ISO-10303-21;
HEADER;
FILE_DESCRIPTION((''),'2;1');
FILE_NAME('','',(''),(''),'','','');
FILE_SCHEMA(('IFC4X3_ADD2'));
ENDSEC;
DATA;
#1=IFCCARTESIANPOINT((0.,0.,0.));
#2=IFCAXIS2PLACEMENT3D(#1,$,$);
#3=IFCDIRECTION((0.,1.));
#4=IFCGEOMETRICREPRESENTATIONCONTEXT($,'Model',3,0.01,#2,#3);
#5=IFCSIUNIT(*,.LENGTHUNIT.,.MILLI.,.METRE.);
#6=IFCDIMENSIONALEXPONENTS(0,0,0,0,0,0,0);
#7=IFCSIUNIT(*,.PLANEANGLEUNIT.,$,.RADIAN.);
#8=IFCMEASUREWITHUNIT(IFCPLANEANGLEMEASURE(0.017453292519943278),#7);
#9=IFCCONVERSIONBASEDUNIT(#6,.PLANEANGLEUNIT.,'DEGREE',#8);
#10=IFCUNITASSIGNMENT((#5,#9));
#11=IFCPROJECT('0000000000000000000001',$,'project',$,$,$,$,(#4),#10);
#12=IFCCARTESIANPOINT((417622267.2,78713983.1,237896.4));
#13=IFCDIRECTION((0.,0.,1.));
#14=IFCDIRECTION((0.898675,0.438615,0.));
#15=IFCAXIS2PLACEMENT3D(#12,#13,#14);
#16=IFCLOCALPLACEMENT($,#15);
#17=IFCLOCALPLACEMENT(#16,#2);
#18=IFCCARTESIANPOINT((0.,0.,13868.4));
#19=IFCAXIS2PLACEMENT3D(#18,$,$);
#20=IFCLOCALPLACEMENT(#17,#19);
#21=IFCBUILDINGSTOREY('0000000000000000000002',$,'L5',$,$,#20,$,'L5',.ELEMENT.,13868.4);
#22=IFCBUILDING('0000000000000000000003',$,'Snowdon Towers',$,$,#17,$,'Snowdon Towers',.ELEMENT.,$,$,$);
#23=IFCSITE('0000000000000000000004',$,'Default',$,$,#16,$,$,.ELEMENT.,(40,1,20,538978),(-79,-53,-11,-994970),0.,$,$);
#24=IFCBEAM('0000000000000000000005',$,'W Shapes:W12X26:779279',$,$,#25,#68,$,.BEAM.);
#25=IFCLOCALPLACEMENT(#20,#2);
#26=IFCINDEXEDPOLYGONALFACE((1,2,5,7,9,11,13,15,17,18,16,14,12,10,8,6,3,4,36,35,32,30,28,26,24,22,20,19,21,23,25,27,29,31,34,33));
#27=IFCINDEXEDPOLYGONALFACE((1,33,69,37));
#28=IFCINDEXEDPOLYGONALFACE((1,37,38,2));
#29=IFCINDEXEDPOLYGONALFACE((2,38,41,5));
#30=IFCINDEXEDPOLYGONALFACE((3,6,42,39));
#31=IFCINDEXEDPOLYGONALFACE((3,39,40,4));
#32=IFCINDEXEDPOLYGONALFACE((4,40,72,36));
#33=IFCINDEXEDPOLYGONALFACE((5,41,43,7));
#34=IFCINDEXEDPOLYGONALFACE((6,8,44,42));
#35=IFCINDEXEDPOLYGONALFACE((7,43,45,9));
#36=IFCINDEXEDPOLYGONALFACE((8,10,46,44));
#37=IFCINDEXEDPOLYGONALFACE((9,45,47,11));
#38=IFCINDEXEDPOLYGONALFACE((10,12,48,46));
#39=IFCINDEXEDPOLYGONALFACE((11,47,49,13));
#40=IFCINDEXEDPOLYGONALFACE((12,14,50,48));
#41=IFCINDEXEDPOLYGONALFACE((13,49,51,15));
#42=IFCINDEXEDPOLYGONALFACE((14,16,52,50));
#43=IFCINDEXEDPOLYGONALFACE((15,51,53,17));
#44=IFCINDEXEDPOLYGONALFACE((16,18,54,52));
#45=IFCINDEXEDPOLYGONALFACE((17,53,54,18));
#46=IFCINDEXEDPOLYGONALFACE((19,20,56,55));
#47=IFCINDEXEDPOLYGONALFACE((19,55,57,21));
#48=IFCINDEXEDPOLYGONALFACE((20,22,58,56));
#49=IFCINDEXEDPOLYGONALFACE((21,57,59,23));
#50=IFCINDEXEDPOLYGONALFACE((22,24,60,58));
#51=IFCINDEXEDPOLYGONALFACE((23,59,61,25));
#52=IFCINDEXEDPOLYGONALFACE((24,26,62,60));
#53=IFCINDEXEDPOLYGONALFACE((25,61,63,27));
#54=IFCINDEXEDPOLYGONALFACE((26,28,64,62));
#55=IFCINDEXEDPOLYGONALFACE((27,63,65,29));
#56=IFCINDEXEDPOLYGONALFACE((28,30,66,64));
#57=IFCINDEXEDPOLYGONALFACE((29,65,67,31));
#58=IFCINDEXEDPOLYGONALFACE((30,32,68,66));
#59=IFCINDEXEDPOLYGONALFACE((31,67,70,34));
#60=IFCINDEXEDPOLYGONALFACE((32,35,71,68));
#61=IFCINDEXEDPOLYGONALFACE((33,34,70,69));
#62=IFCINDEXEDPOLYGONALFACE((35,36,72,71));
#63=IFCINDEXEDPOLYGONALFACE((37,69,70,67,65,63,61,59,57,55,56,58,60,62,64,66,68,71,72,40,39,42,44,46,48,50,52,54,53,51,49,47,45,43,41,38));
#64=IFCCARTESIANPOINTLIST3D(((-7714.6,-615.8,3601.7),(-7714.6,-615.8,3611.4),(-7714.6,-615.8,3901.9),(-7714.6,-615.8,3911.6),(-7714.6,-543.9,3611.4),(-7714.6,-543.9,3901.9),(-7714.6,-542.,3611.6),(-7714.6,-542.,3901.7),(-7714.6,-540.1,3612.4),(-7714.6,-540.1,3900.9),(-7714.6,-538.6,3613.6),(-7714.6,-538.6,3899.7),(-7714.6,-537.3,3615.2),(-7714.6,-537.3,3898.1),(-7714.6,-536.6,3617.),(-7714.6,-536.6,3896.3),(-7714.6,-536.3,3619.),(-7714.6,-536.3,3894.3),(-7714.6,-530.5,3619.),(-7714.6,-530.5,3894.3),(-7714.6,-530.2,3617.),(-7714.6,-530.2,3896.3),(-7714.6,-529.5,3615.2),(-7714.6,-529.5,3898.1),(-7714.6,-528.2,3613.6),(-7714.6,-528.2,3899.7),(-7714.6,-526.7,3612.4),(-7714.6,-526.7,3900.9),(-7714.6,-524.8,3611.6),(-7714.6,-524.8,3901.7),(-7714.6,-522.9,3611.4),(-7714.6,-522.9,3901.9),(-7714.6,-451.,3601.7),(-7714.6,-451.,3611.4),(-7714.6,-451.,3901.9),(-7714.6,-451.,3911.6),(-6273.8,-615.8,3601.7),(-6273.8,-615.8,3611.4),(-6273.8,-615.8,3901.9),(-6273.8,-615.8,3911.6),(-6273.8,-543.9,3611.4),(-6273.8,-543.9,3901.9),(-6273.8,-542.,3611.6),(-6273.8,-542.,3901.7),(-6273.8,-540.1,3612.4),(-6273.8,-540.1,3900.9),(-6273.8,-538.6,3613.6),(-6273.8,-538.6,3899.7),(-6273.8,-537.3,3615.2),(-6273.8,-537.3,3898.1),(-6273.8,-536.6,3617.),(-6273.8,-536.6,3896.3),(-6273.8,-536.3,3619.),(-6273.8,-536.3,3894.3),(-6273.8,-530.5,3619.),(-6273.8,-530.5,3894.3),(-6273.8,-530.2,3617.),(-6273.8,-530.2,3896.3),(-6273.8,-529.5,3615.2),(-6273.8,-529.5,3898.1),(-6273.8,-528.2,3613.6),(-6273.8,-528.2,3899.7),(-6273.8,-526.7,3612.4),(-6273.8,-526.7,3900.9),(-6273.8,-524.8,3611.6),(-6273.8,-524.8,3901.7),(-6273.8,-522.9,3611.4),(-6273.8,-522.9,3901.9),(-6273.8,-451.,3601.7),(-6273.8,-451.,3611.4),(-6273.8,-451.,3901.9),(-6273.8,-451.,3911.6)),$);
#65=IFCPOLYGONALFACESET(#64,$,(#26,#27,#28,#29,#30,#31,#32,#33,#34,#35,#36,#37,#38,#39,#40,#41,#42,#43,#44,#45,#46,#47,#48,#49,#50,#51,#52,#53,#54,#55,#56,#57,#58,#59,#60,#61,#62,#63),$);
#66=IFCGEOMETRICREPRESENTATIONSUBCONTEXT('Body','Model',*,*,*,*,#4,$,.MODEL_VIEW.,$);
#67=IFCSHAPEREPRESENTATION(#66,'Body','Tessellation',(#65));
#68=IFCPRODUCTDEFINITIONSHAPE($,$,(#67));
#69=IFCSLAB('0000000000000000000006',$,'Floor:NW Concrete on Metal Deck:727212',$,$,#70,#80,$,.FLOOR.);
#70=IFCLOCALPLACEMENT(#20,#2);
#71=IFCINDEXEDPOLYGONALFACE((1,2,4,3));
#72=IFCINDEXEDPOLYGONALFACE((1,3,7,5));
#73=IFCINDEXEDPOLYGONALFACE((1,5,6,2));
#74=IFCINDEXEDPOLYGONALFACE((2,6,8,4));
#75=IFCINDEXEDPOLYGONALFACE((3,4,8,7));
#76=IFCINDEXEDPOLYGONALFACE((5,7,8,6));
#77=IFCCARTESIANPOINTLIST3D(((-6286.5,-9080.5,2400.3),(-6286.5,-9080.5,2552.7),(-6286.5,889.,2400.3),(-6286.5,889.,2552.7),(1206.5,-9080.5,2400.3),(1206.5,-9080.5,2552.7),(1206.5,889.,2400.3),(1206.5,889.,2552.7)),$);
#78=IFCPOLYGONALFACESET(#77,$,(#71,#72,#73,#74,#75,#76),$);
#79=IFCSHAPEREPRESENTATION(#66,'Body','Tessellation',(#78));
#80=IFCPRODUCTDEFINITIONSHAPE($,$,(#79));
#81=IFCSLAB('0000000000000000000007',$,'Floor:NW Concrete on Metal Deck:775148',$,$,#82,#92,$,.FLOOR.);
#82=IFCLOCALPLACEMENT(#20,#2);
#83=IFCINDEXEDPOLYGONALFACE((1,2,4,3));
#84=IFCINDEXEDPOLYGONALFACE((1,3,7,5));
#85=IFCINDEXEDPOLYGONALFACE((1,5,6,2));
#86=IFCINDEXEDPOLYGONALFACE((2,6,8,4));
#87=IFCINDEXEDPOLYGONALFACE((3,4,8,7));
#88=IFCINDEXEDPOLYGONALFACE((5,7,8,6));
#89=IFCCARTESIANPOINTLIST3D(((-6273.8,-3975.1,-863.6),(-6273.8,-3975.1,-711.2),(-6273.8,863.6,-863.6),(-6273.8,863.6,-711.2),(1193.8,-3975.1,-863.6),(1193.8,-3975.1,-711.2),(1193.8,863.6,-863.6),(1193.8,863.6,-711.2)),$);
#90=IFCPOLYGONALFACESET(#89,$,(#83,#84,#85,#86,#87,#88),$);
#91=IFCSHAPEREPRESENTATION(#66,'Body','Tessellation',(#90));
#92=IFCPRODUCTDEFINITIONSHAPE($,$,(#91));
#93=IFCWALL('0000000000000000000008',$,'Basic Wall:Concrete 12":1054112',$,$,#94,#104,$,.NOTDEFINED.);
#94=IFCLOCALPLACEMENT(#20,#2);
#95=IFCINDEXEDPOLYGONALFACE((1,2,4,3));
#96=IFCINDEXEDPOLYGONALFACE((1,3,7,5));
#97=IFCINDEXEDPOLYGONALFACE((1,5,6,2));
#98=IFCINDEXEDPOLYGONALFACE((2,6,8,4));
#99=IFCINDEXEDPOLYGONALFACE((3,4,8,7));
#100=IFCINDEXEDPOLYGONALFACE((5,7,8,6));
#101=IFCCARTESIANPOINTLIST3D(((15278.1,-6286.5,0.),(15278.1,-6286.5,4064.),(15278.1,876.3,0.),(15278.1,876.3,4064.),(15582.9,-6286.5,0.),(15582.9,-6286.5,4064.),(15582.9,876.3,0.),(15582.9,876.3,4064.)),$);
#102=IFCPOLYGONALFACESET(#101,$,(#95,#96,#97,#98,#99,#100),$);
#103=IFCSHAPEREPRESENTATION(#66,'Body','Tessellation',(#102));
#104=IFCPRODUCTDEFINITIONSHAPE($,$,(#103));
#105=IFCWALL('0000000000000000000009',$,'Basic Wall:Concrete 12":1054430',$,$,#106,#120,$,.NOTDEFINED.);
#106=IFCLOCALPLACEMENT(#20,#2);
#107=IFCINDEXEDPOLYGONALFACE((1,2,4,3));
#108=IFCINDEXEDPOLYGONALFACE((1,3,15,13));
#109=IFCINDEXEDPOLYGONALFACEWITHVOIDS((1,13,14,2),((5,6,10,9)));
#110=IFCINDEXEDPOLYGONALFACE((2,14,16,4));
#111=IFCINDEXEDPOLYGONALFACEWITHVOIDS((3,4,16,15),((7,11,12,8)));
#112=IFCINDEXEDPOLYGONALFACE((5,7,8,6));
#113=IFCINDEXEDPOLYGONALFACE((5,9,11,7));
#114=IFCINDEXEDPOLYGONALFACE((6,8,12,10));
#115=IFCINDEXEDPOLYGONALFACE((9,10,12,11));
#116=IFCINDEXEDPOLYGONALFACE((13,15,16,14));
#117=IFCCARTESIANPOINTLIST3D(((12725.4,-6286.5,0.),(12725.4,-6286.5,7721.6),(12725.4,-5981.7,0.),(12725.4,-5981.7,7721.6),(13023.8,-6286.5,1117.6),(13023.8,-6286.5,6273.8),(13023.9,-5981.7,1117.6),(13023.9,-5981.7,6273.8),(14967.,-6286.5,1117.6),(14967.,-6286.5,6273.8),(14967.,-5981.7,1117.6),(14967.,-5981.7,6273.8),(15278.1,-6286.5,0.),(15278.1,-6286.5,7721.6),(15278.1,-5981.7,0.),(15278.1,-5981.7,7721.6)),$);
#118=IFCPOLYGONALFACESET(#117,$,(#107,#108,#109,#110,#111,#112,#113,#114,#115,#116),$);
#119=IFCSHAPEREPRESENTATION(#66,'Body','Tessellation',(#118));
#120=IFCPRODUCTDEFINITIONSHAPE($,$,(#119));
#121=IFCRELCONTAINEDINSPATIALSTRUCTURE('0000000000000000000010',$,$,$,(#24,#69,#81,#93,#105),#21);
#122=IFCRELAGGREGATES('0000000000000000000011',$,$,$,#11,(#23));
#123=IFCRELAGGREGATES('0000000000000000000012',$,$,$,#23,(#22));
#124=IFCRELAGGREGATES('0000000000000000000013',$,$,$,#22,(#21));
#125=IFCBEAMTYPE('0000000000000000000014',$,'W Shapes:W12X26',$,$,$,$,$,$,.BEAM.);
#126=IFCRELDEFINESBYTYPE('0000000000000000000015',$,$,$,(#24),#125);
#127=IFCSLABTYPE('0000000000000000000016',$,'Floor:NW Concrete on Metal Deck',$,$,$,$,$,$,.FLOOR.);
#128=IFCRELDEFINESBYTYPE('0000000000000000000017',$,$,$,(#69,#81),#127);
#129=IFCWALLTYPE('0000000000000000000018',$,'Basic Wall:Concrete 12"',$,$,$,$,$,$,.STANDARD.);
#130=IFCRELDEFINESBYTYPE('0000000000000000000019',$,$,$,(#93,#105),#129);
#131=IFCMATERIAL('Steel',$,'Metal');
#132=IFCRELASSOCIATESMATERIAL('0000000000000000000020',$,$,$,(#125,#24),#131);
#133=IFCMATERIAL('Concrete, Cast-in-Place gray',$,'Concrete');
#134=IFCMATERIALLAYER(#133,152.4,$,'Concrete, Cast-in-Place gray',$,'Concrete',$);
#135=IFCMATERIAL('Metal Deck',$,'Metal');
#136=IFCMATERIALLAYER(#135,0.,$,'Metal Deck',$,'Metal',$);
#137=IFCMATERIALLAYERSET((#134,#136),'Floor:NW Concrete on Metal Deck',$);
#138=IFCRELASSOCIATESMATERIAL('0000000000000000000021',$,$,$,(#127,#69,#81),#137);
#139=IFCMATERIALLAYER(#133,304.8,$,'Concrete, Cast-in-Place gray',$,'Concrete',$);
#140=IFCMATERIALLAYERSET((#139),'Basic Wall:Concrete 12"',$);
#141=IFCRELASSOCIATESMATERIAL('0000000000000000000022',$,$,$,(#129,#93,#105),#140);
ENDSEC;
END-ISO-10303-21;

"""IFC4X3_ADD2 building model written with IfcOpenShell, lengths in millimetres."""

from ifc_helpers import new_model, entity, si_unit, converted_unit, direction, frame, frame_2d, origin, place, context, subcontext, project, spatial, polyline, circle_curve, parameter, trimmed, segment, composite_curve, rectangle, i_section, outline, extrude, source, transform, mapped, material, layer, layer_set, layer_usage, material_profile, profile_set, profile_usage, type_object, type_shapes, element, save


model = new_model("IFC4X3_ADD2")

# Units and contexts
model_context = context("Model", 3, precision=0.01, world=origin(), true_north=direction((0.0, 1.0)))
body_context = subcontext(model_context, "Body", "Model", "MODEL_VIEW")
ifc_project = project(units=[si_unit("LENGTHUNIT", "METRE", prefix="MILLI"), converted_unit("PLANEANGLEUNIT", "DEGREE", entity("IfcPlaneAngleMeasure", 0.017453292519943278), si_unit("PLANEANGLEUNIT", "RADIAN"), dimensions=[0, 0, 0, 0, 0, 0, 0])], contexts=[model_context])

# Site, building, storey
site_placement = place(None, frame((417622267.2, 78713983.1, 237896.4), z_axis=(0.0, 0.0, 1.0), x_axis=(0.898675, 0.438615, 0.0)))
site = spatial("IfcSite", under=ifc_project, at=site_placement, Name="Default", CompositionType="ELEMENT", RefLatitude=(40, 1, 20, 538978), RefLongitude=(-79, -53, -11, -994970), RefElevation=0.0)
building_placement = place(site_placement, origin())
building = spatial("IfcBuilding", under=site, at=building_placement, Name="Snowdon Towers", LongName="Snowdon Towers", CompositionType="ELEMENT")
storey_placement = place(building_placement, frame((0.0, 0.0, 13868.4)))
storey = spatial("IfcBuildingStorey", under=building, at=storey_placement, Name="L5", LongName="L5", CompositionType="ELEMENT", Elevation=13868.4)

# Shared definitions
ifc_material_1 = material(Name="Steel", Category="Metal")

# Beam
ifc_material_profile_1 = material_profile(ifc_material_1, outline(composite_curve([segment(polyline([(-82.4, -145.3), (-82.4, -154.9)]), True, "CONTINUOUS"), segment(polyline([(-82.4, -154.9), (82.4, -154.9)]), True, "CONTINUOUS"), segment(polyline([(82.4, -154.9), (82.4, -145.3)]), True, "CONTINUOUS"), segment(polyline([(82.4, -145.3), (10.5, -145.3)]), True, "CONTINUOUS"), segment(trimmed(circle_curve(frame_2d((10.5, -137.7), x_axis=(1.0, 0.0)), 7.6), [parameter(180.0)], [parameter(270.0)], True, "PARAMETER"), False, "CONTINUOUS"), segment(polyline([(2.9, -137.7), (2.9, 137.7)]), True, "CONTINUOUS"), segment(trimmed(circle_curve(frame_2d((10.5, 137.7), x_axis=(1.0, 0.0)), 7.6), [parameter(90.0)], [parameter(180.0)], True, "PARAMETER"), False, "CONTINUOUS"), segment(polyline([(10.5, 145.3), (82.4, 145.3)]), True, "CONTINUOUS"), segment(polyline([(82.4, 145.3), (82.4, 154.9)]), True, "CONTINUOUS"), segment(polyline([(82.4, 154.9), (-82.4, 154.9)]), True, "CONTINUOUS"), segment(polyline([(-82.4, 154.9), (-82.4, 145.3)]), True, "CONTINUOUS"), segment(polyline([(-82.4, 145.3), (-10.5, 145.3)]), True, "CONTINUOUS"), segment(trimmed(circle_curve(frame_2d((-10.5, 137.7), x_axis=(1.0, 0.0)), 7.6), [parameter(360.0)], [parameter(90.0)], True, "PARAMETER"), False, "CONTINUOUS"), segment(polyline([(-2.9, 137.7), (-2.9, -137.7)]), True, "CONTINUOUS"), segment(trimmed(circle_curve(frame_2d((-10.5, -137.7), x_axis=(1.0, 0.0)), 7.6), [parameter(270.0)], [parameter(360.0)], True, "PARAMETER"), False, "CONTINUOUS"), segment(polyline([(-10.5, -145.3), (-82.4, -145.3)]), True, "CONTINUOUS")], self_intersect=False)), Name="W12X26")
ifc_profile_set_1 = profile_set([ifc_material_profile_1], Name="W12X26")
ifc_profile_usage_1 = profile_usage(ifc_profile_set_1, cardinal=8)
beam_type_1 = type_object("IfcBeamType", Name="W Shapes:W12X26", PredefinedType="BEAM", material=ifc_profile_set_1)
shared_shape_1 = source(origin(), body_context, "Body", "SweptSolid", [
    extrude(i_section(OverallWidth=164.8, OverallDepth=309.9, WebThickness=5.8, FlangeThickness=9.7, FilletRadius=7.6, at=frame_2d((0.0, 0.0), x_axis=(0.0, 1.0))), frame((-6273.8, -533.4, 17625.1), z_axis=(-1.0, 0.0, 0.0), x_axis=(0.0, 0.0, -1.0)), (0.0, 0.0, 1.0), 1440.8),
])
type_shapes(beam_type_1, [shared_shape_1])
beam_1_placement = place(storey_placement, frame((0.0, 0.0, -13868.4)))
element("IfcBeam", 1, at=beam_1_placement, inside=storey, type_object=beam_type_1, material=ifc_profile_usage_1, Name="W Shapes:W12X26:779279", PredefinedType="BEAM", context=body_context, shape_type="MappedRepresentation", body=[
    mapped(shared_shape_1, transform((0.0, 0.0, 0.0), scale=1.0)),
])

# Slabs
ifc_material_2 = material(Name="Concrete, Cast-in-Place gray", Category="Concrete")
ifc_layer_1 = layer(ifc_material_2, 152.4, Name="Concrete, Cast-in-Place gray", Category="Concrete")
ifc_material_3 = material(Name="Metal Deck", Category="Metal")
ifc_layer_2 = layer(ifc_material_3, 0.0, Name="Metal Deck", Category="Metal")
ifc_layer_set_1 = layer_set([ifc_layer_1, ifc_layer_2], Name="Floor:NW Concrete on Metal Deck")
ifc_layer_usage_1 = layer_usage(ifc_layer_set_1, "AXIS3", "POSITIVE", 0.0)
slab_type = type_object("IfcSlabType", Name="Floor:NW Concrete on Metal Deck", PredefinedType="FLOOR", material=ifc_layer_set_1)
slab_1_placement = place(storey_placement, origin())
element("IfcSlab", 2, at=slab_1_placement, inside=storey, type_object=slab_type, material=ifc_layer_usage_1, Name="Floor:NW Concrete on Metal Deck:727212", PredefinedType="FLOOR", context=body_context, shape_type="SweptSolid", body=[
    extrude(rectangle(XDim=9969.5, YDim=7493.0, at=frame_2d((0.0, 0.0), x_axis=(1.0, 0.0))), frame((-2540.0, -4095.8, 2552.7), z_axis=(0.0, 0.0, -1.0), x_axis=(0.0, 1.0, 0.0)), (0.0, 0.0, 1.0), 152.4),
])
ifc_layer_usage_2 = layer_usage(ifc_layer_set_1, "AXIS3", "POSITIVE", 0.0)
slab_2_placement = place(storey_placement, origin())
element("IfcSlab", 3, at=slab_2_placement, inside=storey, type_object=slab_type, material=ifc_layer_usage_2, Name="Floor:NW Concrete on Metal Deck:775148", PredefinedType="FLOOR", context=body_context, shape_type="SweptSolid", body=[
    extrude(rectangle(XDim=4838.7, YDim=7467.6, at=frame_2d((0.0, 0.0), x_axis=(1.0, 0.0))), frame((-2540.0, -1555.8, -711.2), z_axis=(0.0, 0.0, -1.0), x_axis=(0.0, 1.0, 0.0)), (0.0, 0.0, 1.0), 152.4),
])

# Wall
ifc_layer_3 = layer(ifc_material_2, 304.8, Name="Concrete, Cast-in-Place gray", Category="Concrete")
ifc_layer_set_2 = layer_set([ifc_layer_3], Name="Basic Wall:Concrete 12\"")
wall_type = type_object("IfcWallType", Name="Basic Wall:Concrete 12\"", PredefinedType="STANDARD", material=ifc_layer_set_2)
wall_1_placement = place(storey_placement, frame((15430.5, -6286.5, 0.0), z_axis=(0.0, 0.0, 1.0), x_axis=(0.0, 1.0, 0.0)))
element("IfcWall", 4, at=wall_1_placement, inside=storey, type_object=wall_type, material=ifc_layer_set_2, Name="Basic Wall:Concrete 12\":1054112", PredefinedType="NOTDEFINED", context=body_context, shape_type="SweptSolid", body=[
    extrude(rectangle(XDim=7162.8, YDim=304.8, at=frame_2d((3581.4, 0.0), x_axis=(-1.0, 0.0))), origin(), (0.0, 0.0, 1.0), 4064.0),
])

# Wall, opening
wall_2_placement = place(storey_placement, frame((15278.1, -6134.1, 0.0), z_axis=(0.0, 0.0, 1.0), x_axis=(-1.0, 0.0, 0.0)))
wall_2 = element("IfcWall", 5, at=wall_2_placement, inside=storey, type_object=wall_type, material=ifc_layer_set_2, Name="Basic Wall:Concrete 12\":1054430", PredefinedType="NOTDEFINED", context=body_context, shape_type="SweptSolid", body=[
    extrude(rectangle(XDim=2552.7, YDim=304.8, at=frame_2d((1276.3, 0.0), x_axis=(-1.0, 0.0))), origin(), (0.0, 0.0, 1.0), 7721.6),
])
opening_1_placement = place(wall_2_placement, origin())
element("IfcOpeningElement", 6, at=opening_1_placement, cuts=wall_2, PredefinedType="OPENING", context=body_context, shape_type="SweptSolid", body=[
    extrude(rectangle(XDim=5156.2, YDim=1943.1, at=frame_2d((0.0, 0.0), x_axis=(1.0, 0.0))), frame((1282.7, 152.4, 3695.7), z_axis=(0.0, -1.0, 0.0), x_axis=(0.0, 0.0, -1.0)), (0.0, 0.0, 1.0), 304.8),
])

save(model, "model.ifc")
